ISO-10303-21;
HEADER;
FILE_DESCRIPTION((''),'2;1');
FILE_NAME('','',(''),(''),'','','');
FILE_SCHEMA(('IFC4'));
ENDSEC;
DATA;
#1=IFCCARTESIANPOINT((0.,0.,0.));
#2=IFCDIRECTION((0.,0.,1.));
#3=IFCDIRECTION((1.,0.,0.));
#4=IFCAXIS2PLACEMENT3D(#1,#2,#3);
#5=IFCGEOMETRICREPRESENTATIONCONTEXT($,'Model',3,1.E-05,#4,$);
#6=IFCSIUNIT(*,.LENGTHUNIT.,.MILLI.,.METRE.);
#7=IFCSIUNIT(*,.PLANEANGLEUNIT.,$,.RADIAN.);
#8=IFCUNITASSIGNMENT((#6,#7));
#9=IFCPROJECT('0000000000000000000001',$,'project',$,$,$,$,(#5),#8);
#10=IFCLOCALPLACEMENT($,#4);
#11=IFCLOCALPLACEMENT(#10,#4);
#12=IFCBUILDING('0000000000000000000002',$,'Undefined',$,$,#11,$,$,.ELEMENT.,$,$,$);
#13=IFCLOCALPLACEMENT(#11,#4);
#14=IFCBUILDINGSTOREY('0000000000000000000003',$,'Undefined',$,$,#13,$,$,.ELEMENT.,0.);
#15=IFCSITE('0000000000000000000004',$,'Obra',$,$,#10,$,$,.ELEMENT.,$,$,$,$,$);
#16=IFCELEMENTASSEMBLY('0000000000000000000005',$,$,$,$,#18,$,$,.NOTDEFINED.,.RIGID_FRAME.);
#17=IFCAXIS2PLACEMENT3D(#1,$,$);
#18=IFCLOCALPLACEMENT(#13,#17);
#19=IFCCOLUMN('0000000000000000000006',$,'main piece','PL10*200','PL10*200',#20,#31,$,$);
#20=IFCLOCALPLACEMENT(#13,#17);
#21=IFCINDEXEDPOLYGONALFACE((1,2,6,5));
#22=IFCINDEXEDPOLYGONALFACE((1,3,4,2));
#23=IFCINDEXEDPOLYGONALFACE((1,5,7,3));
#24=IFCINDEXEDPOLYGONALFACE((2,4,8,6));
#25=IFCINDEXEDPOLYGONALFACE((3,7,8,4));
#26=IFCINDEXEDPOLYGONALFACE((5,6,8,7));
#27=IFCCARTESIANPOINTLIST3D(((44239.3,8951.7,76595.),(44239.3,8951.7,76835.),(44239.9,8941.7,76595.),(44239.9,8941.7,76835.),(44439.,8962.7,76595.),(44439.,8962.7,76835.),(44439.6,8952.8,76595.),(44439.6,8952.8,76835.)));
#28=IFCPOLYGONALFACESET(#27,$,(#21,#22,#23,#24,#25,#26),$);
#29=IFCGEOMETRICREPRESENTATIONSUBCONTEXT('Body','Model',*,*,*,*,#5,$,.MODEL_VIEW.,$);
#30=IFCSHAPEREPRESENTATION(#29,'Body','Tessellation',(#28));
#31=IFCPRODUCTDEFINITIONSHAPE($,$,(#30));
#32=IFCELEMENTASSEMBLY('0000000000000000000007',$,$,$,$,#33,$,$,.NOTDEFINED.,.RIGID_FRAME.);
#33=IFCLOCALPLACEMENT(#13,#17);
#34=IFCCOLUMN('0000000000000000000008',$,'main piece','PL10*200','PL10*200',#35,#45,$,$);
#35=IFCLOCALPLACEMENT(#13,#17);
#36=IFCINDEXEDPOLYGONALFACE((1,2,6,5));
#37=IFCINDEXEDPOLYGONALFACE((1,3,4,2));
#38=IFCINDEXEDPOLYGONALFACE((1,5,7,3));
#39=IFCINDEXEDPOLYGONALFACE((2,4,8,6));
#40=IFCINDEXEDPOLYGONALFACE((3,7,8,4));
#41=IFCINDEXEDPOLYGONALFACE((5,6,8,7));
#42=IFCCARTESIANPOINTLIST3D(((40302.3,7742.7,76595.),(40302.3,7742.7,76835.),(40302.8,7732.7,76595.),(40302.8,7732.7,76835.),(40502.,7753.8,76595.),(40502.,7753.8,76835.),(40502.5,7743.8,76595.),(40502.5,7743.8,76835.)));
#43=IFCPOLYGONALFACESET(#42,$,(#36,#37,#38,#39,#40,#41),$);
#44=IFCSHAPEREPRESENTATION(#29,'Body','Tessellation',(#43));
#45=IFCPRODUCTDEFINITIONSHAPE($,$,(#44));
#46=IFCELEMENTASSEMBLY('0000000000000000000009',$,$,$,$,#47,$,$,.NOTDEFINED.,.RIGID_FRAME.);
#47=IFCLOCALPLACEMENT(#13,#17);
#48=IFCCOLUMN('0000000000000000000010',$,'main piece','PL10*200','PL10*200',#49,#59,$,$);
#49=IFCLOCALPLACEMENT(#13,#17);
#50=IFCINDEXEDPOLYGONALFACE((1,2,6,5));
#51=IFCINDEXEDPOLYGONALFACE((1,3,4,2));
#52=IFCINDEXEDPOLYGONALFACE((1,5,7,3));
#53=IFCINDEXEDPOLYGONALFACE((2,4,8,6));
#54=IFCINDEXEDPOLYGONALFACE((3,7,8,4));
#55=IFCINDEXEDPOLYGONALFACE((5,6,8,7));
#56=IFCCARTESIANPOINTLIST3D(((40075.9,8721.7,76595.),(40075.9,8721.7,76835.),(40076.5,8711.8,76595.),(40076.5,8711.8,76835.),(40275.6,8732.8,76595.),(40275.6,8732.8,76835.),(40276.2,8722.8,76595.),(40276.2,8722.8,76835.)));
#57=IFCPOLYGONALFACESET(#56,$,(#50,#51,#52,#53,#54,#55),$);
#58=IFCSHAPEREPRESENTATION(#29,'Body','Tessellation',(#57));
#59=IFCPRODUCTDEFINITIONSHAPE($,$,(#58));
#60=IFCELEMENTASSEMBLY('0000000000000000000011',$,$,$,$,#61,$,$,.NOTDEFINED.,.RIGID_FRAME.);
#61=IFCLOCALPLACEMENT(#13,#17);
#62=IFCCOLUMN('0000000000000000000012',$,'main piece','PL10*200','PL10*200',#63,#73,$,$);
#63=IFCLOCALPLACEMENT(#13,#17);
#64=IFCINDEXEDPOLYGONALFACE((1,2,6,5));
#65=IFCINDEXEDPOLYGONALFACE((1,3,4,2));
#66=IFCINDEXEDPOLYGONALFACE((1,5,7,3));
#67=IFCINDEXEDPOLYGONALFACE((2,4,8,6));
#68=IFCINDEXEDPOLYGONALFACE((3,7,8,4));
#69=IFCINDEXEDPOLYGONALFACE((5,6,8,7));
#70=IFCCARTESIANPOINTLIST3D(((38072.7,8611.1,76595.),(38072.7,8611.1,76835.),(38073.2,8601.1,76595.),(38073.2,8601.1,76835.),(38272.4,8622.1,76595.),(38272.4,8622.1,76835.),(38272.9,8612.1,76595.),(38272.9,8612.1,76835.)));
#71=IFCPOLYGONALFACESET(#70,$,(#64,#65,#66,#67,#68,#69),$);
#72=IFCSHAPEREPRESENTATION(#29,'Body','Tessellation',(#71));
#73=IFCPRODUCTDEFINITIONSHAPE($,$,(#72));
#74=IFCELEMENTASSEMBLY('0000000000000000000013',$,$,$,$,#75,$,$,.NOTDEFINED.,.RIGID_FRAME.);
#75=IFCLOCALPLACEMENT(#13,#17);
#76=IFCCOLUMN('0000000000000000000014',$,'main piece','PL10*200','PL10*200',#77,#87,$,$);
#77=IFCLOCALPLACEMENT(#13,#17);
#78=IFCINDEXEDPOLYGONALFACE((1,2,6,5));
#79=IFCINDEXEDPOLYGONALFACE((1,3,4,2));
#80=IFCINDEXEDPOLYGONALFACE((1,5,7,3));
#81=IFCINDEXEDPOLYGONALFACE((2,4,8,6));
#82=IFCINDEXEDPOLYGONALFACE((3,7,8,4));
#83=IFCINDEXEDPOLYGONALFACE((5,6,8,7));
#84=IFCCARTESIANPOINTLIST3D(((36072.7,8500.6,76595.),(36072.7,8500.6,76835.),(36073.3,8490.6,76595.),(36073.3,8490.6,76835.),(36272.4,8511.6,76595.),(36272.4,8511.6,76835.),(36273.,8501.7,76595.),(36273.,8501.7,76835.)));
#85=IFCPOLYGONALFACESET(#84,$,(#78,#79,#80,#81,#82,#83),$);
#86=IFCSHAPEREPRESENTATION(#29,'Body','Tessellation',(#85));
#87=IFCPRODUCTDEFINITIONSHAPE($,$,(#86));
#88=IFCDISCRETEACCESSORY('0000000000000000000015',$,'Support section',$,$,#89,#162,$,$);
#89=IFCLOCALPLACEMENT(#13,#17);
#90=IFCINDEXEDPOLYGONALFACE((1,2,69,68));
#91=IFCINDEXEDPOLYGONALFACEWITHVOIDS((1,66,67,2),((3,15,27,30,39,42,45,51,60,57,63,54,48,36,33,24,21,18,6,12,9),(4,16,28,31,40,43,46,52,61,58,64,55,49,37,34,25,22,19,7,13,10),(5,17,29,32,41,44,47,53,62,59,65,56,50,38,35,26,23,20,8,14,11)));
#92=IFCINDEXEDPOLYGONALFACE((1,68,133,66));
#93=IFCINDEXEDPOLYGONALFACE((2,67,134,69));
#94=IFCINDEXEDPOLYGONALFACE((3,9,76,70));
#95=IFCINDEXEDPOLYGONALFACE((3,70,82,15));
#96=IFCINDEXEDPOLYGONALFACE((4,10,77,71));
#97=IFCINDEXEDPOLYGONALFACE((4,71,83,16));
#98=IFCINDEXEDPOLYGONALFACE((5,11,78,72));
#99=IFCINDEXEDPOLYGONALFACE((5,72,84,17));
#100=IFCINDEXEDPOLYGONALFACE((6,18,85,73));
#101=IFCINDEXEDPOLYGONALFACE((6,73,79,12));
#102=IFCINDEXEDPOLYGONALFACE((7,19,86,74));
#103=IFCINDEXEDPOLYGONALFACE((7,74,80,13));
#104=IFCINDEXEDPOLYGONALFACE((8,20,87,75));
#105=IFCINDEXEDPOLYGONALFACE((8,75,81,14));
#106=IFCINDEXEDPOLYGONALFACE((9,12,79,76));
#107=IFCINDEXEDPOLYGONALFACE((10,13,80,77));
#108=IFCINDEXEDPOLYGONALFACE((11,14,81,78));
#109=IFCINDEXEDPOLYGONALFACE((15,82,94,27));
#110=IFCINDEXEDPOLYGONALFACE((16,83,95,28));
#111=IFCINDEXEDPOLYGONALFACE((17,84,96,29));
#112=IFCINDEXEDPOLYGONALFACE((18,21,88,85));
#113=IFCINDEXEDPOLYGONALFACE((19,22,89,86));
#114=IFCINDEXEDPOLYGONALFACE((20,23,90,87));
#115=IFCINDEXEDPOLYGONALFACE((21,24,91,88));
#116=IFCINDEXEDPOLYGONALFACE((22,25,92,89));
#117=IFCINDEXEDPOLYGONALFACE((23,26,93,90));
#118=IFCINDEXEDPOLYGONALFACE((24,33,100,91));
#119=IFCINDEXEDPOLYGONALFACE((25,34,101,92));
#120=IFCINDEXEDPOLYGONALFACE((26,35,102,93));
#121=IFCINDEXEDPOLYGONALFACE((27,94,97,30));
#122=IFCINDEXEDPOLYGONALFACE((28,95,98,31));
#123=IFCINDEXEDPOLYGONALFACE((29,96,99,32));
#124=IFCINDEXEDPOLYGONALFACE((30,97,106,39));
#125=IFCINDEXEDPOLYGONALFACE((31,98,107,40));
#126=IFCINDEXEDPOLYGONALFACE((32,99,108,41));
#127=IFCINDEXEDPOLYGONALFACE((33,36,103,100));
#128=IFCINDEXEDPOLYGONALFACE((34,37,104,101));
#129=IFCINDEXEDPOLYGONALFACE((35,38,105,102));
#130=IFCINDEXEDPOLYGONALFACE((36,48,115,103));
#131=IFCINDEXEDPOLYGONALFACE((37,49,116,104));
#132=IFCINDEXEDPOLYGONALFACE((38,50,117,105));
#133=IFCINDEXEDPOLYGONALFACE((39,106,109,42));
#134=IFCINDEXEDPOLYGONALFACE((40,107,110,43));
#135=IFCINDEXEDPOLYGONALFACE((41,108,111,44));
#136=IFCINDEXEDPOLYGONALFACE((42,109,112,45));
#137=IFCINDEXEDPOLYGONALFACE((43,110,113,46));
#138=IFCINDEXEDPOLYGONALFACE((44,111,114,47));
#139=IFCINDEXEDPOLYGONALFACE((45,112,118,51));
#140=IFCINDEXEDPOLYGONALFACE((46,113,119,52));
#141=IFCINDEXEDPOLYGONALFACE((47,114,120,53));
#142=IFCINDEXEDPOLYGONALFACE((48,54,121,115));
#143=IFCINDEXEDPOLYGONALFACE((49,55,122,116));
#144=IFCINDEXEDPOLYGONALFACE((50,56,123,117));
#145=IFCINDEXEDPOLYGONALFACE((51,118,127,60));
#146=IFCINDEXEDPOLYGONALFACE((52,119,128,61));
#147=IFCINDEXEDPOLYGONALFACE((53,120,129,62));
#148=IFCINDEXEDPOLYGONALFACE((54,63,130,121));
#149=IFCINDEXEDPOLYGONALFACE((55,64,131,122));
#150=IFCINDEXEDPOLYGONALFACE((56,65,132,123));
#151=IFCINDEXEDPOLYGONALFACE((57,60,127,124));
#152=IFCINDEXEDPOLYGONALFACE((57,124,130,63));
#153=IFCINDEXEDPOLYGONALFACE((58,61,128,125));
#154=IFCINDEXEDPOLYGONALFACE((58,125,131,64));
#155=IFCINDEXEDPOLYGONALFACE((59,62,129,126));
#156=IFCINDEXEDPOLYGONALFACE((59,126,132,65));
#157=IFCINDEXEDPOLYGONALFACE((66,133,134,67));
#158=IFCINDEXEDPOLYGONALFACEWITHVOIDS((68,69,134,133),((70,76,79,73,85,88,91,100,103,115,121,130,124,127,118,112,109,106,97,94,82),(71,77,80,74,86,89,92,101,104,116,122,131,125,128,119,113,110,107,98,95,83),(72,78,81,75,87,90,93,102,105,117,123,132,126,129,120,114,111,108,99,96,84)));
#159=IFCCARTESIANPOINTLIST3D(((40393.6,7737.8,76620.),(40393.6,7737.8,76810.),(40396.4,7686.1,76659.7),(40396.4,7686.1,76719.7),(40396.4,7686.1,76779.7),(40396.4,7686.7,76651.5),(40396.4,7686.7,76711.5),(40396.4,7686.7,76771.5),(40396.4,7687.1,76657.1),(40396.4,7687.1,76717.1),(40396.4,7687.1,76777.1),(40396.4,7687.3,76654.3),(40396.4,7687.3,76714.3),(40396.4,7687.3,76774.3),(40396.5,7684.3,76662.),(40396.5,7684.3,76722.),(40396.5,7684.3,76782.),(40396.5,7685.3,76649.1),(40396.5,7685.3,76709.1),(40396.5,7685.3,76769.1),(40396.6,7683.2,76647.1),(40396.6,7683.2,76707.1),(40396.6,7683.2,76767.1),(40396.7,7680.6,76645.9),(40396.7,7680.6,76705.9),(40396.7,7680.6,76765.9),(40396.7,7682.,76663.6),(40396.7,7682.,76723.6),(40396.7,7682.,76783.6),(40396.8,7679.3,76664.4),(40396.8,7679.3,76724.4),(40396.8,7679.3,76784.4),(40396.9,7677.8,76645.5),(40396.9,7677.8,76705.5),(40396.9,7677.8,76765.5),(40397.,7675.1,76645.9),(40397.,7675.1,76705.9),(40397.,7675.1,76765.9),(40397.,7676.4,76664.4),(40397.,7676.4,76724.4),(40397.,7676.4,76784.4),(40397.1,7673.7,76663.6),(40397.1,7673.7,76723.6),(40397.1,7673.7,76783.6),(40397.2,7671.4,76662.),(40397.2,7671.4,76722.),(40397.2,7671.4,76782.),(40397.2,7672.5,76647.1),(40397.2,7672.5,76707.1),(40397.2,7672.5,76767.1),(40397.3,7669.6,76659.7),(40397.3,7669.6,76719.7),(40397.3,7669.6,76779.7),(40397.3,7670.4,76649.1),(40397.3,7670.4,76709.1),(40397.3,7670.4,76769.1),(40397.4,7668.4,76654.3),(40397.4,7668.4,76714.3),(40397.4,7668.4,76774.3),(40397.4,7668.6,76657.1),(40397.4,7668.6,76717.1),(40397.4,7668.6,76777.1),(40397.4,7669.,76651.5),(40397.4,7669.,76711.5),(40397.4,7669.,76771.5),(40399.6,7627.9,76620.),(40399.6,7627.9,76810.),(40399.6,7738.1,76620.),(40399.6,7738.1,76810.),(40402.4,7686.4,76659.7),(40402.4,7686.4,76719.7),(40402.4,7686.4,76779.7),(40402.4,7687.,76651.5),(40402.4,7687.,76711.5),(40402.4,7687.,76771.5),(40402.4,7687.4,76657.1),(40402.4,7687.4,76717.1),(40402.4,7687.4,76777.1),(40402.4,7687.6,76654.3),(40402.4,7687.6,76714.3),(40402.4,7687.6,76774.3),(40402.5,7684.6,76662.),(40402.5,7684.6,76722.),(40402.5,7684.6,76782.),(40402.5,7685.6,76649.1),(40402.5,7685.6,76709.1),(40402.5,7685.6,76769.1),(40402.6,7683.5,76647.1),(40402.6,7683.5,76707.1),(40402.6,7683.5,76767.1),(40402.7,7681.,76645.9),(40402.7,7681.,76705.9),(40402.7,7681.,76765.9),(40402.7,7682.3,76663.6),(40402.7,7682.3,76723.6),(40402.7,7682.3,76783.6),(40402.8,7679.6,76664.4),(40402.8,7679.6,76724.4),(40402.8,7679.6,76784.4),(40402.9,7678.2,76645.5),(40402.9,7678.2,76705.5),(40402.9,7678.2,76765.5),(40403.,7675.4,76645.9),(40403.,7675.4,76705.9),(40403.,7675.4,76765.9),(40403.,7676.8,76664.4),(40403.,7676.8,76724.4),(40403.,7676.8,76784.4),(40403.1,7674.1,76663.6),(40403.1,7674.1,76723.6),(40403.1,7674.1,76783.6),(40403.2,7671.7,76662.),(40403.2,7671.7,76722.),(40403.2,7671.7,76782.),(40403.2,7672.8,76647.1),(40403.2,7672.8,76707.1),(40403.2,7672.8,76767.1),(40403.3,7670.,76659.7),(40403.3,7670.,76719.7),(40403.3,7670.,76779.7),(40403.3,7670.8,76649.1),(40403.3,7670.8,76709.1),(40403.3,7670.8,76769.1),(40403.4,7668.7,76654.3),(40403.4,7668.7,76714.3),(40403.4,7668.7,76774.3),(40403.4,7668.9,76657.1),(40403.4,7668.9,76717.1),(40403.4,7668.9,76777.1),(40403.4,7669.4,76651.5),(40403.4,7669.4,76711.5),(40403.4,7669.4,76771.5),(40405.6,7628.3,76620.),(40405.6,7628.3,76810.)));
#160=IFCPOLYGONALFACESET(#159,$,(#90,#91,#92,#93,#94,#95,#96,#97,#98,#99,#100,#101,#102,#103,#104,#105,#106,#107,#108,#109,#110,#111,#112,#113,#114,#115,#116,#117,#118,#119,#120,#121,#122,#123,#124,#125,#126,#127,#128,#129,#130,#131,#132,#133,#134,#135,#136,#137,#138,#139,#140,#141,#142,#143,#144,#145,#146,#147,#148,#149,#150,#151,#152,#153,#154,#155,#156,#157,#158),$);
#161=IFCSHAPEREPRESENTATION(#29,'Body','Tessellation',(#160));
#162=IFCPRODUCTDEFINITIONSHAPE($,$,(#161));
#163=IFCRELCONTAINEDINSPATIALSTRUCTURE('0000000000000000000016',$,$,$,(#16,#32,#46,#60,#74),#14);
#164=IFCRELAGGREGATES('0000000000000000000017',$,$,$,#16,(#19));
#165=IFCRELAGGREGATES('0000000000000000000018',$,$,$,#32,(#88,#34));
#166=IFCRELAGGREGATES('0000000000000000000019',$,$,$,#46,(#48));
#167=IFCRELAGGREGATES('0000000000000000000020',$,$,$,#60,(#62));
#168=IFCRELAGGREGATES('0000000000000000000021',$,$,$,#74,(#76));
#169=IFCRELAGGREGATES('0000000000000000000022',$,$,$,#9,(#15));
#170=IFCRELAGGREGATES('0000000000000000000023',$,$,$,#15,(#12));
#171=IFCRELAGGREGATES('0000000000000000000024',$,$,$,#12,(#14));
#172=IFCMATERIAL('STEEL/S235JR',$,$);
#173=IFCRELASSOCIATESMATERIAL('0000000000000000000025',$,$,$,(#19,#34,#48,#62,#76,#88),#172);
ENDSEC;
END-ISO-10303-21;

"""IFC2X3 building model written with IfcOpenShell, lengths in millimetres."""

from ifc_helpers import new_model, si_unit, frame, origin_with_axes, origin_2d_with_axis, place, context, subcontext, project, spatial, rectangle, circle, extrude, source, transform, mapped, material, element, aggregate, save


model = new_model("IFC2X3")

# Units and contexts
model_context = context("Model", 3, precision=1e-05, world=origin_with_axes())
body_context = subcontext(model_context, "Body", "Model", "MODEL_VIEW")
ifc_project = project(units=[si_unit("LENGTHUNIT", "METRE", prefix="MILLI"), si_unit("PLANEANGLEUNIT", "RADIAN")], contexts=[model_context])

# Site, building, storey
site_placement = place(None, origin_with_axes())
site = spatial("IfcSite", under=ifc_project, at=site_placement, Name="Obra", CompositionType="ELEMENT")
building_placement = place(site_placement, origin_with_axes())
building = spatial("IfcBuilding", under=site, at=building_placement, Name="Undefined", CompositionType="ELEMENT")
storey_placement = place(building_placement, origin_with_axes())
storey = spatial("IfcBuildingStorey", under=building, at=storey_placement, Name="Undefined", CompositionType="ELEMENT", Elevation=0.0)

# Element assemblies, columns
assembly_1_placement = place(storey_placement, origin_with_axes())
assembly_1 = element("IfcElementAssembly", 1, at=assembly_1_placement, inside=storey, AssemblyPlace="NOTDEFINED", PredefinedType="RIGID_FRAME")
ifc_material = material(Name="STEEL/S235JR")
column_1_placement = place(assembly_1_placement, frame((44339.4, 8952.2, 76595.0), z_axis=(0.0, 0.0, 1.0), x_axis=(0.998478, 0.055152, 0.0)))
column_1 = element("IfcColumn", 2, at=column_1_placement, material=ifc_material, Name="main piece", Description="PL10*200", ObjectType="PL10*200", context=body_context, shape_type="SweptSolid", body=[
    extrude(rectangle(XDim=10.0, YDim=200.0, at=origin_2d_with_axis()), frame((0.0, 0.0, 240.0), z_axis=(0.0, 0.0, -1.0), x_axis=(0.0, 1.0, 0.0)), (0.0, 0.0, 1.0), 240.0),
])
aggregate(assembly_1, [column_1])
assembly_2_placement = place(storey_placement, origin_with_axes())
assembly_2 = element("IfcElementAssembly", 3, at=assembly_2_placement, inside=storey, AssemblyPlace="NOTDEFINED", PredefinedType="RIGID_FRAME")
column_2_placement = place(assembly_2_placement, frame((40402.4, 7743.3, 76595.0), z_axis=(0.0, 0.0, 1.0), x_axis=(-0.998478, -0.055152, 0.0)))
column_2 = element("IfcColumn", 4, at=column_2_placement, material=ifc_material, Name="main piece", Description="PL10*200", ObjectType="PL10*200", context=body_context, shape_type="SweptSolid", body=[
    extrude(rectangle(XDim=10.0, YDim=200.0, at=origin_2d_with_axis()), frame((0.0, 0.0, 240.0), z_axis=(0.0, 0.0, -1.0), x_axis=(0.0, 1.0, 0.0)), (0.0, 0.0, 1.0), 240.0),
])
assembly_3_placement = place(storey_placement, origin_with_axes())
assembly_3 = element("IfcElementAssembly", 5, at=assembly_3_placement, inside=storey, AssemblyPlace="NOTDEFINED", PredefinedType="RIGID_FRAME")
column_3_placement = place(assembly_3_placement, frame((40176.0, 8722.3, 76595.0), z_axis=(0.0, 0.0, 1.0), x_axis=(0.998478, 0.055152, 0.0)))
column_3 = element("IfcColumn", 6, at=column_3_placement, material=ifc_material, Name="main piece", Description="PL10*200", ObjectType="PL10*200", context=body_context, shape_type="SweptSolid", body=[
    extrude(rectangle(XDim=10.0, YDim=200.0, at=origin_2d_with_axis()), frame((0.0, 0.0, 240.0), z_axis=(0.0, 0.0, -1.0), x_axis=(0.0, 1.0, 0.0)), (0.0, 0.0, 1.0), 240.0),
])
assembly_4_placement = place(storey_placement, origin_with_axes())
assembly_4 = element("IfcElementAssembly", 7, at=assembly_4_placement, inside=storey, AssemblyPlace="NOTDEFINED", PredefinedType="RIGID_FRAME")
column_4_placement = place(assembly_4_placement, frame((38172.8, 8611.6, 76595.0), z_axis=(0.0, 0.0, 1.0), x_axis=(0.998478, 0.055152, 0.0)))
column_4 = element("IfcColumn", 8, at=column_4_placement, material=ifc_material, Name="main piece", Description="PL10*200", ObjectType="PL10*200", context=body_context, shape_type="SweptSolid", body=[
    extrude(rectangle(XDim=10.0, YDim=200.0, at=origin_2d_with_axis()), frame((0.0, 0.0, 240.0), z_axis=(0.0, 0.0, -1.0), x_axis=(0.0, 1.0, 0.0)), (0.0, 0.0, 1.0), 240.0),
])
assembly_5_placement = place(storey_placement, origin_with_axes())
assembly_5 = element("IfcElementAssembly", 9, at=assembly_5_placement, inside=storey, AssemblyPlace="NOTDEFINED", PredefinedType="RIGID_FRAME")
column_5_placement = place(assembly_5_placement, frame((36172.8, 8501.1, 76595.0), z_axis=(0.0, 0.0, 1.0), x_axis=(0.998478, 0.055152, 0.0)))
column_5 = element("IfcColumn", 10, at=column_5_placement, material=ifc_material, Name="main piece", Description="PL10*200", ObjectType="PL10*200", context=body_context, shape_type="SweptSolid", body=[
    extrude(rectangle(XDim=10.0, YDim=200.0, at=origin_2d_with_axis()), frame((0.0, 0.0, 240.0), z_axis=(0.0, 0.0, -1.0), x_axis=(0.0, 1.0, 0.0)), (0.0, 0.0, 1.0), 240.0),
])

# Discrete accessory, opening
discrete_accessory_1_placement = place(assembly_2_placement, frame((40399.6, 7683.0, 76620.0), z_axis=(0.0, 0.0, 1.0), x_axis=(-0.055152, 0.998478, 0.0)))
discrete_accessory_1 = element("IfcDiscreteAccessory", 11, at=discrete_accessory_1_placement, material=ifc_material, Name="Support section", context=body_context, shape_type="SweptSolid", body=[
    extrude(rectangle(XDim=6.0, YDim=110.0, at=origin_2d_with_axis()), frame((0.0, 0.0, 190.0), z_axis=(0.0, 0.0, -1.0), x_axis=(0.0, 1.0, 0.0)), (0.0, 0.0, 1.0), 190.0),
])
shared_shape_1 = source(origin_with_axes(), body_context, "Body", "SweptSolid", [
    extrude(circle(Radius=9.5, at=origin_2d_with_axis()), frame((0.0, -9.2, 0.0), z_axis=(0.0, 1.0, 0.0), x_axis=(1.0, 0.0, 0.0)), (0.0, 0.0, 1.0), 6.2),
])
opening_1_placement = place(assembly_2_placement, frame((40403.2, 7728.3, 76835.0), z_axis=(0.055152, -0.998478, 0.0), x_axis=(0.0, 0.0, -1.0)))
element("IfcOpeningElement", 12, at=opening_1_placement, cuts=discrete_accessory_1, ObjectType="Opening", context=body_context, shape_type="MappedRepresentation", body=[
    mapped(shared_shape_1, transform((60.0, 0.0, 50.0))),
    mapped(shared_shape_1, transform((120.0, 0.0, 50.0))),
    mapped(shared_shape_1, transform((180.0, 0.0, 50.0))),
])
aggregate(assembly_2, [discrete_accessory_1, column_2])
aggregate(assembly_3, [column_3])
aggregate(assembly_4, [column_4])
aggregate(assembly_5, [column_5])

save(model, "model.ifc")
